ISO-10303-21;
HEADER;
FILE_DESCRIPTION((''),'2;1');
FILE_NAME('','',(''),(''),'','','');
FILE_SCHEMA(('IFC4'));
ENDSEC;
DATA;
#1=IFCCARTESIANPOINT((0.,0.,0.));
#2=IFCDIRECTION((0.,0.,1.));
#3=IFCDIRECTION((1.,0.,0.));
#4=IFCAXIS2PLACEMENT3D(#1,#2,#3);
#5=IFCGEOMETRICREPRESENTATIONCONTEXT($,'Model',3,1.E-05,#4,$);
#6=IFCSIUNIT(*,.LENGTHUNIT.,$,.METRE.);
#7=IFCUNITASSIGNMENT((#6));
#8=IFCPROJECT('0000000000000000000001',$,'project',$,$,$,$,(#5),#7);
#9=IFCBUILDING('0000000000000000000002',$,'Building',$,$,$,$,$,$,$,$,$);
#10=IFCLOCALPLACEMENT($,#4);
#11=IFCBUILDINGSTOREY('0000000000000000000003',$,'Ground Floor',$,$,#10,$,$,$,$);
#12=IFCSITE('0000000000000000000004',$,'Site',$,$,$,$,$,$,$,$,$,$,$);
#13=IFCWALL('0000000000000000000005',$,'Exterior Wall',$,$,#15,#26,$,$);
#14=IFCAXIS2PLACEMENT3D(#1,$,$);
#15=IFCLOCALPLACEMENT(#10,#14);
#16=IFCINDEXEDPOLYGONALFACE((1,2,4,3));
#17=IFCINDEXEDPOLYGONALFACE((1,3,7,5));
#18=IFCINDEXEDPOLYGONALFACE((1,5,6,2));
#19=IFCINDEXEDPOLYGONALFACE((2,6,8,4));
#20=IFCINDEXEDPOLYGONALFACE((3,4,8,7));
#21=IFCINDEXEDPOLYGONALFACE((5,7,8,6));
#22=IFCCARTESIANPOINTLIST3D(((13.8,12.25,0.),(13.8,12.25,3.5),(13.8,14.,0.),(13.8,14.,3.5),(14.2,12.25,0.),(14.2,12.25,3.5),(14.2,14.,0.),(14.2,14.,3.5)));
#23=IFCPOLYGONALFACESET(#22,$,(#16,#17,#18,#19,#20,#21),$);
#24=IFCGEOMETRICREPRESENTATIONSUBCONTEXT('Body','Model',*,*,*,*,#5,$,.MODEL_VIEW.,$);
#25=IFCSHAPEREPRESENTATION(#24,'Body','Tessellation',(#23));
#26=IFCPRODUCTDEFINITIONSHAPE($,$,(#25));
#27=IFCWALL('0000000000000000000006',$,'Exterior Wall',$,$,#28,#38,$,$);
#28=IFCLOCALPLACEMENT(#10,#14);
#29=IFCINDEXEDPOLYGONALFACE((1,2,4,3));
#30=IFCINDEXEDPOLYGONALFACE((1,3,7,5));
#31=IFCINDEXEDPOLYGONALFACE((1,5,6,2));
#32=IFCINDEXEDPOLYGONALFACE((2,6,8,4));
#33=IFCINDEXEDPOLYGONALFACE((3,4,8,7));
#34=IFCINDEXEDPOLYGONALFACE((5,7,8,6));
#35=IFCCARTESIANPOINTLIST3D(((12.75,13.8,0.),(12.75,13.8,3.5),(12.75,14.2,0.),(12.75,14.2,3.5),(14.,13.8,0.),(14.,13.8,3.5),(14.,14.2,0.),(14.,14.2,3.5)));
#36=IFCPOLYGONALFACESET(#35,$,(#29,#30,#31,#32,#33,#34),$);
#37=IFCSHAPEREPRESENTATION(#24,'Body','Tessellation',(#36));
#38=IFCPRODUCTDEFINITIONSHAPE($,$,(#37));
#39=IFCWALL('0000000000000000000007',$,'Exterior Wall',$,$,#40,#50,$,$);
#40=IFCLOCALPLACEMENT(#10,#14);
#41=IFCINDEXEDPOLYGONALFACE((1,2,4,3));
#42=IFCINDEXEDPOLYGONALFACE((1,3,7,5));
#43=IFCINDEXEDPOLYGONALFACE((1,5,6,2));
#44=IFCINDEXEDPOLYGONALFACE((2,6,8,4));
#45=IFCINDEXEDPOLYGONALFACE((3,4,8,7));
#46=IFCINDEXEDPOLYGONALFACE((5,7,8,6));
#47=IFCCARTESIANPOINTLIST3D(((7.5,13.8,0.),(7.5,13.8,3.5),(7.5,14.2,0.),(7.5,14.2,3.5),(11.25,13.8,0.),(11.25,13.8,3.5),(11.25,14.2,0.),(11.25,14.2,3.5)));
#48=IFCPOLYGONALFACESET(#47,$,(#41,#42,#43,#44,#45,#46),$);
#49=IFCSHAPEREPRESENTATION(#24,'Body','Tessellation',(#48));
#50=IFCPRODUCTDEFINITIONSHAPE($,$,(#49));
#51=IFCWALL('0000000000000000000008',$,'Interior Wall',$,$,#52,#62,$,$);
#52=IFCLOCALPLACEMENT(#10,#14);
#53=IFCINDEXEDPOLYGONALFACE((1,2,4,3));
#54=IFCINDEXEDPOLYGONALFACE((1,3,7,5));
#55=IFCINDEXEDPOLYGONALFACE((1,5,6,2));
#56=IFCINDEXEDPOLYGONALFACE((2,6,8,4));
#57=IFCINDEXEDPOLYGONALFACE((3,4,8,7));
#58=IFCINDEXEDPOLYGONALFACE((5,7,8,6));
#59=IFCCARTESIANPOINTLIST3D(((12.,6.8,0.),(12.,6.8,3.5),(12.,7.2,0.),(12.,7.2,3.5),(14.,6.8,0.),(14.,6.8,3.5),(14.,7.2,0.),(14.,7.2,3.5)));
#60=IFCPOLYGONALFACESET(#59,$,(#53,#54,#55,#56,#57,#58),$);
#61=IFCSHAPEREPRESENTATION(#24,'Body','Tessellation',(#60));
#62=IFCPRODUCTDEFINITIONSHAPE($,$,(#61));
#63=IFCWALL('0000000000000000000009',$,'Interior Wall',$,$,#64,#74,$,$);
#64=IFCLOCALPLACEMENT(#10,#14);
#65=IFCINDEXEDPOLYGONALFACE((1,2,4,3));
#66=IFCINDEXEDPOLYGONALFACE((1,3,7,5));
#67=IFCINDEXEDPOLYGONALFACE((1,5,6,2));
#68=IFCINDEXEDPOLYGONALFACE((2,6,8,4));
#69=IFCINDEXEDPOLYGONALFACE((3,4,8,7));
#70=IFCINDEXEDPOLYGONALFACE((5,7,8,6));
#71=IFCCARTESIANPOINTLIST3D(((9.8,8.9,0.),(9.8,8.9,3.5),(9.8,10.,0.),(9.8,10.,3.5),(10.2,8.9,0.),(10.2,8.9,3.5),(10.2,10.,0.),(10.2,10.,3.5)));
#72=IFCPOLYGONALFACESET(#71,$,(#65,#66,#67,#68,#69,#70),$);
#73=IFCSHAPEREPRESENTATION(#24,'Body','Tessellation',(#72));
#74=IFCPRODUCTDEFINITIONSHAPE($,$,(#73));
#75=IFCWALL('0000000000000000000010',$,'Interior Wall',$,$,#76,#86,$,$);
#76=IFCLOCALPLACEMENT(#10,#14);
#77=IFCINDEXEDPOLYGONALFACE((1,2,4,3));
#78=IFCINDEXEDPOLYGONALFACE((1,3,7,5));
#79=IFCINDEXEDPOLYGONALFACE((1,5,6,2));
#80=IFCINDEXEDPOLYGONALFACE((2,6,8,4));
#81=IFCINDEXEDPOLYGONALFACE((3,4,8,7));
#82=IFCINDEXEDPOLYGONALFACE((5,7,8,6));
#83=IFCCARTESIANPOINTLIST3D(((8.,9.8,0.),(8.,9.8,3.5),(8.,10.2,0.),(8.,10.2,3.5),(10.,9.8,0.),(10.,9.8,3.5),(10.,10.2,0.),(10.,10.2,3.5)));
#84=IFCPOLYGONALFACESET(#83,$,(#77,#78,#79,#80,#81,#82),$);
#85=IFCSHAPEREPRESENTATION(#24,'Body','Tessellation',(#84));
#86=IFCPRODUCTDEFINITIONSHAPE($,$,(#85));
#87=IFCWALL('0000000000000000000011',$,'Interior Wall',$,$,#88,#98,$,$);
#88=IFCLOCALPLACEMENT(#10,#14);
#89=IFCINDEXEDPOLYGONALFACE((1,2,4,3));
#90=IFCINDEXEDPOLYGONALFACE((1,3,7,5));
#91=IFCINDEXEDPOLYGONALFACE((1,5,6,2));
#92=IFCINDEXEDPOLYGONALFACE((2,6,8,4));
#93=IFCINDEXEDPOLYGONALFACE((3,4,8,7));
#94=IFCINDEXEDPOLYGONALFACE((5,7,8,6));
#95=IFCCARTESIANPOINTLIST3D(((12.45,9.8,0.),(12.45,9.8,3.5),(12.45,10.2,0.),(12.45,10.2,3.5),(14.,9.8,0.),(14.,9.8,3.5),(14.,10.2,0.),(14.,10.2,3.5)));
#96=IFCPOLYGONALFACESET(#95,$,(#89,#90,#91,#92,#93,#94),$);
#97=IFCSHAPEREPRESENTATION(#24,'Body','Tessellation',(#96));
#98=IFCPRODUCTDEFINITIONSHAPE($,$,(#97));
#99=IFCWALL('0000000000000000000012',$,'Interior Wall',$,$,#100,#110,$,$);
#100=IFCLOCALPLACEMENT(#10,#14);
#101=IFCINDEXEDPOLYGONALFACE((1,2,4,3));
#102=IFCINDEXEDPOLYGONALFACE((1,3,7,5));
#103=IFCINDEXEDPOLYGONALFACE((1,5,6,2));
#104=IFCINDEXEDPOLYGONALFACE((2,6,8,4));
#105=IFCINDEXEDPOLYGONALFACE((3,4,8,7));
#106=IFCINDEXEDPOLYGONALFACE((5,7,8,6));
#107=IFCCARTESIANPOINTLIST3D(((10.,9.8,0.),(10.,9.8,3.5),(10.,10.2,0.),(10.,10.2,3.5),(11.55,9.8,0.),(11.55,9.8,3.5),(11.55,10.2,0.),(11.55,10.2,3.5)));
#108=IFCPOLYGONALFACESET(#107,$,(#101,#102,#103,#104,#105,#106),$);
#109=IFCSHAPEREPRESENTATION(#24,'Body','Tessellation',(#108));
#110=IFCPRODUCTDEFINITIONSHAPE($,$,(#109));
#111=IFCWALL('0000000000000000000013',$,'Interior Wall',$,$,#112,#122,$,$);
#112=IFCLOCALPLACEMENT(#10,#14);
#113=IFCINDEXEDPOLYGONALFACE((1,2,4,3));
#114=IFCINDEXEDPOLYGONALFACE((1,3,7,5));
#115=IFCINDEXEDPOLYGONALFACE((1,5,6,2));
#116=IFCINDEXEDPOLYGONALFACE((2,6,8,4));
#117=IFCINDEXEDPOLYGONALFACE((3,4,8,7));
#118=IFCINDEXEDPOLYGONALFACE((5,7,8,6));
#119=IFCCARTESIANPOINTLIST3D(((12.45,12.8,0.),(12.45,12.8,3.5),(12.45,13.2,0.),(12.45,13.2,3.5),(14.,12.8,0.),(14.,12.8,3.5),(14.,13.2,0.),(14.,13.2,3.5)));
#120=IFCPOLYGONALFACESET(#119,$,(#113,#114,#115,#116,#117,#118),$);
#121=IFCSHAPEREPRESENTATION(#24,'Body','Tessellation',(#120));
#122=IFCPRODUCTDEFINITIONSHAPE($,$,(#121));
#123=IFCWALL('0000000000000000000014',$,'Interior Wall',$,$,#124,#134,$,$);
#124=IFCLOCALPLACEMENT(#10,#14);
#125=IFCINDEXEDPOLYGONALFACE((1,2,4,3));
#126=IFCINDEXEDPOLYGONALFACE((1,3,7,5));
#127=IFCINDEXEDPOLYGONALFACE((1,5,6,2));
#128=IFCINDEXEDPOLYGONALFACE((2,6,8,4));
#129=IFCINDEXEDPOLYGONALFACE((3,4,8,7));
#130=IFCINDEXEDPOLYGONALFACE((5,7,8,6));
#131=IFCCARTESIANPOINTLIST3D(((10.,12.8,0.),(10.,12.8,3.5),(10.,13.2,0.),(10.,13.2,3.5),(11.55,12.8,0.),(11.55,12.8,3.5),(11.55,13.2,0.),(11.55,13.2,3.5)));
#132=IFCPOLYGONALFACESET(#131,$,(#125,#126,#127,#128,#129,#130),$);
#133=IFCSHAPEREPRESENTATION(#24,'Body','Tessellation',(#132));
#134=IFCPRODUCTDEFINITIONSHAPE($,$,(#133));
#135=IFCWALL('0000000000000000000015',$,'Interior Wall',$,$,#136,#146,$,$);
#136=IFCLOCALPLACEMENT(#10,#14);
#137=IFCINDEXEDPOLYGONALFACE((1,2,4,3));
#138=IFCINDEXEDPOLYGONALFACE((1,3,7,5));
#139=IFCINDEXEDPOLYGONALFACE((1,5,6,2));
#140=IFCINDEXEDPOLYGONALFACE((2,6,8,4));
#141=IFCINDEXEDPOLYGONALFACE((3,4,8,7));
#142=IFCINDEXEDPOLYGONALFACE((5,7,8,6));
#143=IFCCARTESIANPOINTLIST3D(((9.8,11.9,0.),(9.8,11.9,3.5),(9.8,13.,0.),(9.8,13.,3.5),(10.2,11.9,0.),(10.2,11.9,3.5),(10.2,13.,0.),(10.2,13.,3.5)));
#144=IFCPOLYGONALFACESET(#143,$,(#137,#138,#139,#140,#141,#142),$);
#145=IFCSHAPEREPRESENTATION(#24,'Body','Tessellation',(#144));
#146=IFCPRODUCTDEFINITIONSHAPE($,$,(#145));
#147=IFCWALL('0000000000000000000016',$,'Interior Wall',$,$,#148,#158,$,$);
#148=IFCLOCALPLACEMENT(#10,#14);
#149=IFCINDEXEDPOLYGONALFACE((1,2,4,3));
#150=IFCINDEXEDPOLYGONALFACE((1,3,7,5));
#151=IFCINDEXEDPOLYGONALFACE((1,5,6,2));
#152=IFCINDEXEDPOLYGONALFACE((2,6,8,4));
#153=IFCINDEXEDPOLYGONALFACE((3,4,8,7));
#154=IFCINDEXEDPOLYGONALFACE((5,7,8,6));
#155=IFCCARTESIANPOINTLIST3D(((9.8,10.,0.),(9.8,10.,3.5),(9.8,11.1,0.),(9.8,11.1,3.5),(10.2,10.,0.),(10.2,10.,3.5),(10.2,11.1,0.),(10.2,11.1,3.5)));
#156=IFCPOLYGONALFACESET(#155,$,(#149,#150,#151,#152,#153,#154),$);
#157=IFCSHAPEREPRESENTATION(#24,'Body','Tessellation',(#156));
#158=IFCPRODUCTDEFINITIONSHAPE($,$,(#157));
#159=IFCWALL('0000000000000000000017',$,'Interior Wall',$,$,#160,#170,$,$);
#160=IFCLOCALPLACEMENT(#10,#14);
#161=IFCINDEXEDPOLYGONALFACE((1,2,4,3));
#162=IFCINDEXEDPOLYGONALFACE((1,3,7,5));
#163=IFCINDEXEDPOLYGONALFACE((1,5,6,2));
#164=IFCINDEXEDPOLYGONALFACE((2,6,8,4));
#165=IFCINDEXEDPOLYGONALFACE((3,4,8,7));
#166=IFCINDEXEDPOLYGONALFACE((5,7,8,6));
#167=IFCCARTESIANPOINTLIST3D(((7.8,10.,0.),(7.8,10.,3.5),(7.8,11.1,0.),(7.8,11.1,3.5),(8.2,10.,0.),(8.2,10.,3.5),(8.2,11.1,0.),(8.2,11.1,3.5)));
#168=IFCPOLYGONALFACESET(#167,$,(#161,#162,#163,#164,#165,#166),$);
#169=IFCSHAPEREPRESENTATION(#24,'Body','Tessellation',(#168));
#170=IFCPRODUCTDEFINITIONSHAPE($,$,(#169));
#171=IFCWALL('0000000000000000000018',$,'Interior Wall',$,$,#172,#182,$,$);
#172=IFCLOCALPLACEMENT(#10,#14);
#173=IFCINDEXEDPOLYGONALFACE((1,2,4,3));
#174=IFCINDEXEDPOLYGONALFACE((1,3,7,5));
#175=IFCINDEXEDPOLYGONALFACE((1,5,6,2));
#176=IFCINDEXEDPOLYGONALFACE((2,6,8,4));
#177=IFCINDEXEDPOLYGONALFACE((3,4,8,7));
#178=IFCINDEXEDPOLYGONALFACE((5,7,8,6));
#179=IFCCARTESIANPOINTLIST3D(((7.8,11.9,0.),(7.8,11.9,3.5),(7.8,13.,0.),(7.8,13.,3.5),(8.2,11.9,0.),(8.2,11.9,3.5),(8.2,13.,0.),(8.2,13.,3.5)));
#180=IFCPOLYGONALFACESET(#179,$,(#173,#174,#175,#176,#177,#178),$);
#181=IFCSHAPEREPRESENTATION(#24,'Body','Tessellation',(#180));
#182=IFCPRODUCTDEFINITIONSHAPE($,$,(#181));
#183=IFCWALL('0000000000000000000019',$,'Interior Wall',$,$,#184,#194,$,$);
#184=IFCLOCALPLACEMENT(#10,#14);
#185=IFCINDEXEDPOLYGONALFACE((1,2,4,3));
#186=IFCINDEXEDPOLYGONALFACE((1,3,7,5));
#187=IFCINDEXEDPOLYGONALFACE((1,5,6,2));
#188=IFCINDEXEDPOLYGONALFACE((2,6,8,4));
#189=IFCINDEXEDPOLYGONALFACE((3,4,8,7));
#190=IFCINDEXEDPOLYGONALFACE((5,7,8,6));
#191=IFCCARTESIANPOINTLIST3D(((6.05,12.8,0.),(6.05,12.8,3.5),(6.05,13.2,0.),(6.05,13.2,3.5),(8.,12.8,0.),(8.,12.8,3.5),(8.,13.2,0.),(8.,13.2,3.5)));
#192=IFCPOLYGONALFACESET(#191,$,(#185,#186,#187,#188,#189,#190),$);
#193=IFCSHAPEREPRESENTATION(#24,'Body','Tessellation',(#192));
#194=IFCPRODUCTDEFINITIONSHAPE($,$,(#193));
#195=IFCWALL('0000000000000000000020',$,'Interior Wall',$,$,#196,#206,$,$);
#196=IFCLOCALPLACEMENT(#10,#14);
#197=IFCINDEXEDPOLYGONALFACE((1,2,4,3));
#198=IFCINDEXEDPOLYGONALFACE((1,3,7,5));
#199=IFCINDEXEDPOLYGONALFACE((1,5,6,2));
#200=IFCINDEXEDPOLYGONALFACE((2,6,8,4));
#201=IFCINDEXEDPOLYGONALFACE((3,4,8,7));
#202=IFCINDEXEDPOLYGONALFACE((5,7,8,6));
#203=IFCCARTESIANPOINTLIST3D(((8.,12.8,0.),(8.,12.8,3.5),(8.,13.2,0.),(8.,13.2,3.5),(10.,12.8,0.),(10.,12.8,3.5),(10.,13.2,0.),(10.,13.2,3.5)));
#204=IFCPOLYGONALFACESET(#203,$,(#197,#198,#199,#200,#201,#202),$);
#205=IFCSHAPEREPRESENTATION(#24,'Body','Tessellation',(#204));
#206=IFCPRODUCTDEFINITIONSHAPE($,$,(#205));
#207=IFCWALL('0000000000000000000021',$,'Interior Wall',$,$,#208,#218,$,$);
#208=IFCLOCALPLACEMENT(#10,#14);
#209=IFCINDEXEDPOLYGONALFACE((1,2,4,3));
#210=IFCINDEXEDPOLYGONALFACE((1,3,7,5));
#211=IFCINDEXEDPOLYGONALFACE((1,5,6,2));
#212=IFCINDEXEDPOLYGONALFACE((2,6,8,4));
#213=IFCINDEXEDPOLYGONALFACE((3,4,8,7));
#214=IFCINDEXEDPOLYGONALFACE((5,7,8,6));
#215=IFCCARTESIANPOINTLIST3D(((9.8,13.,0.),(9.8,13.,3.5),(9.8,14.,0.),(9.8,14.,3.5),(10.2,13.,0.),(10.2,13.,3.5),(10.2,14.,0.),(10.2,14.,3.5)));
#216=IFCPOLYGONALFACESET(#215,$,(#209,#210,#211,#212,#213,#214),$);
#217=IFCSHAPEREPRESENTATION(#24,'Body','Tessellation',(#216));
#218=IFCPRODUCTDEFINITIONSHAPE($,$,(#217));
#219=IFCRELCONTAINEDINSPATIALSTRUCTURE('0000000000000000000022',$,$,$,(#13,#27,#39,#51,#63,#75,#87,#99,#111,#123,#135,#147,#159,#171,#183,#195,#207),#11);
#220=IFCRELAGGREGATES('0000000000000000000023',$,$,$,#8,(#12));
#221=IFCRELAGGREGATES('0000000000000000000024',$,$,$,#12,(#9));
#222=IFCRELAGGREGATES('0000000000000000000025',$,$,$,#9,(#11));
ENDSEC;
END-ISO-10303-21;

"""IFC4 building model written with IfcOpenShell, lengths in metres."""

from ifc_helpers import new_model, si_unit, frame, origin_with_axes, place, context, subcontext, project, spatial, indexed_curve, outline, extrude, element, save


model = new_model("IFC4")

# Units and contexts
model_context = context("Model", 3, precision=1e-05, world=origin_with_axes())
body_context = subcontext(model_context, "Body", "Model", "MODEL_VIEW")
ifc_project = project(units=[si_unit("LENGTHUNIT", "METRE")], contexts=[model_context])

# Site, building, storey
site = spatial("IfcSite", under=ifc_project, Name="Site")
building = spatial("IfcBuilding", under=site, Name="Building")
storey_placement = place(None, origin_with_axes())
storey = spatial("IfcBuildingStorey", under=building, at=storey_placement, Name="Ground Floor")

# Walls
wall_1_placement = place(storey_placement, frame((14.0, 12.25, 0.0), z_axis=(0.0, 0.0, 1.0), x_axis=(0.0, 1.0, 0.0)))
element("IfcWall", 1, at=wall_1_placement, inside=storey, Name="Exterior Wall", context=body_context, shape_type="SweptSolid", body=[
    extrude(outline(indexed_curve([(0.0, 0.0), (0.0, 0.4), (1.75, 0.4), (1.75, 0.0), (0.0, 0.0)], self_intersect=False)), frame((0.0, -0.2, 0.0), z_axis=(0.0, 0.0, 1.0), x_axis=(1.0, 0.0, 0.0)), (0.0, 0.0, 1.0), 3.5),
])
wall_2_placement = place(storey_placement, frame((14.0, 14.0, 0.0), z_axis=(0.0, 0.0, 1.0), x_axis=(-1.0, 0.0, 0.0)))
element("IfcWall", 2, at=wall_2_placement, inside=storey, Name="Exterior Wall", context=body_context, shape_type="SweptSolid", body=[
    extrude(outline(indexed_curve([(0.0, 0.0), (0.0, 0.4), (1.25, 0.4), (1.25, 0.0), (0.0, 0.0)], self_intersect=False)), frame((0.0, -0.2, 0.0), z_axis=(0.0, 0.0, 1.0), x_axis=(1.0, 0.0, 0.0)), (0.0, 0.0, 1.0), 3.5),
])
wall_3_placement = place(storey_placement, frame((11.25, 14.0, 0.0), z_axis=(0.0, 0.0, 1.0), x_axis=(-1.0, 0.0, 0.0)))
element("IfcWall", 3, at=wall_3_placement, inside=storey, Name="Exterior Wall", context=body_context, shape_type="SweptSolid", body=[
    extrude(outline(indexed_curve([(0.0, 0.0), (0.0, 0.4), (3.75, 0.4), (3.75, 0.0), (0.0, 0.0)], self_intersect=False)), frame((0.0, -0.2, 0.0), z_axis=(0.0, 0.0, 1.0), x_axis=(1.0, 0.0, 0.0)), (0.0, 0.0, 1.0), 3.5),
])
wall_4_placement = place(storey_placement, frame((14.0, 7.0, 0.0), z_axis=(0.0, 0.0, 1.0), x_axis=(-1.0, 0.0, 0.0)))
element("IfcWall", 4, at=wall_4_placement, inside=storey, Name="Interior Wall", context=body_context, shape_type="SweptSolid", body=[
    extrude(outline(indexed_curve([(0.0, 0.0), (0.0, 0.4), (2.0, 0.4), (2.0, 0.0), (0.0, 0.0)], self_intersect=False)), frame((0.0, -0.2, 0.0), z_axis=(0.0, 0.0, 1.0), x_axis=(1.0, 0.0, 0.0)), (0.0, 0.0, 1.0), 3.5),
])
wall_5_placement = place(storey_placement, frame((10.0, 8.9, 0.0), z_axis=(0.0, 0.0, 1.0), x_axis=(0.0, 1.0, 0.0)))
element("IfcWall", 5, at=wall_5_placement, inside=storey, Name="Interior Wall", context=body_context, shape_type="SweptSolid", body=[
    extrude(outline(indexed_curve([(0.0, 0.0), (0.0, 0.4), (1.1, 0.4), (1.1, 0.0), (0.0, 0.0)], self_intersect=False)), frame((0.0, -0.2, 0.0), z_axis=(0.0, 0.0, 1.0), x_axis=(1.0, 0.0, 0.0)), (0.0, 0.0, 1.0), 3.5),
])
wall_6_placement = place(storey_placement, frame((10.0, 10.0, 0.0), z_axis=(0.0, 0.0, 1.0), x_axis=(-1.0, 0.0, 0.0)))
element("IfcWall", 6, at=wall_6_placement, inside=storey, Name="Interior Wall", context=body_context, shape_type="SweptSolid", body=[
    extrude(outline(indexed_curve([(0.0, 0.0), (0.0, 0.4), (2.0, 0.4), (2.0, 0.0), (0.0, 0.0)], self_intersect=False)), frame((0.0, -0.2, 0.0), z_axis=(0.0, 0.0, 1.0), x_axis=(1.0, 0.0, 0.0)), (0.0, 0.0, 1.0), 3.5),
])
for number, where, z_axis, x_axis, name in (
    (7, (14.0, 10.0, 0.0), (0.0, 0.0, 1.0), (-1.0, 0.0, 0.0), "Interior Wall"),
    (8, (11.55, 10.0, 0.0), (0.0, 0.0, 1.0), (-1.0, 0.0, 0.0), "Interior Wall"),
    (9, (14.0, 13.0, 0.0), (0.0, 0.0, 1.0), (-1.0, 0.0, 0.0), "Interior Wall"),
    (10, (11.55, 13.0, 0.0), (0.0, 0.0, 1.0), (-1.0, 0.0, 0.0), "Interior Wall"),
):
    element("IfcWall", number, at=place(storey_placement, frame(where, z_axis=z_axis, x_axis=x_axis)), inside=storey, Name=name, context=body_context, shape_type="SweptSolid", body=[
        extrude(outline(indexed_curve([(0.0, 0.0), (0.0, 0.4), (1.55, 0.4), (1.55, 0.0), (0.0, 0.0)], self_intersect=False)), frame((0.0, -0.2, 0.0), z_axis=(0.0, 0.0, 1.0), x_axis=(1.0, 0.0, 0.0)), (0.0, 0.0, 1.0), 3.5),
    ])
for number, where, z_axis, x_axis, name in (
    (11, (10.0, 13.0, 0.0), (0.0, 0.0, 1.0), (0.0, -1.0, 0.0), "Interior Wall"),
    (12, (10.0, 11.1, 0.0), (0.0, 0.0, 1.0), (0.0, -1.0, 0.0), "Interior Wall"),
    (13, (8.0, 10.0, 0.0), (0.0, 0.0, 1.0), (0.0, 1.0, 0.0), "Interior Wall"),
    (14, (8.0, 11.9, 0.0), (0.0, 0.0, 1.0), (0.0, 1.0, 0.0), "Interior Wall"),
):
    element("IfcWall", number, at=place(storey_placement, frame(where, z_axis=z_axis, x_axis=x_axis)), inside=storey, Name=name, context=body_context, shape_type="SweptSolid", body=[
        extrude(outline(indexed_curve([(0.0, 0.0), (0.0, 0.4), (1.1, 0.4), (1.1, 0.0), (0.0, 0.0)], self_intersect=False)), frame((0.0, -0.2, 0.0), z_axis=(0.0, 0.0, 1.0), x_axis=(1.0, 0.0, 0.0)), (0.0, 0.0, 1.0), 3.5),
    ])
wall_7_placement = place(storey_placement, frame((8.0, 13.0, 0.0), z_axis=(0.0, 0.0, 1.0), x_axis=(-1.0, 0.0, 0.0)))
element("IfcWall", 15, at=wall_7_placement, inside=storey, Name="Interior Wall", context=body_context, shape_type="SweptSolid", body=[
    extrude(outline(indexed_curve([(0.0, 0.0), (0.0, 0.4), (1.95, 0.4), (1.95, 0.0), (0.0, 0.0)], self_intersect=False)), frame((0.0, -0.2, 0.0), z_axis=(0.0, 0.0, 1.0), x_axis=(1.0, 0.0, 0.0)), (0.0, 0.0, 1.0), 3.5),
])
wall_8_placement = place(storey_placement, frame((10.0, 13.0, 0.0), z_axis=(0.0, 0.0, 1.0), x_axis=(-1.0, 0.0, 0.0)))
element("IfcWall", 16, at=wall_8_placement, inside=storey, Name="Interior Wall", context=body_context, shape_type="SweptSolid", body=[
    extrude(outline(indexed_curve([(0.0, 0.0), (0.0, 0.4), (2.0, 0.4), (2.0, 0.0), (0.0, 0.0)], self_intersect=False)), frame((0.0, -0.2, 0.0), z_axis=(0.0, 0.0, 1.0), x_axis=(1.0, 0.0, 0.0)), (0.0, 0.0, 1.0), 3.5),
])
wall_9_placement = place(storey_placement, frame((10.0, 13.0, 0.0), z_axis=(0.0, 0.0, 1.0), x_axis=(0.0, 1.0, 0.0)))
element("IfcWall", 17, at=wall_9_placement, inside=storey, Name="Interior Wall", context=body_context, shape_type="SweptSolid", body=[
    extrude(outline(indexed_curve([(0.0, 0.0), (0.0, 0.4), (1.0, 0.4), (1.0, 0.0), (0.0, 0.0)], self_intersect=False)), frame((0.0, -0.2, 0.0), z_axis=(0.0, 0.0, 1.0), x_axis=(1.0, 0.0, 0.0)), (0.0, 0.0, 1.0), 3.5),
])

save(model, "model.ifc")
